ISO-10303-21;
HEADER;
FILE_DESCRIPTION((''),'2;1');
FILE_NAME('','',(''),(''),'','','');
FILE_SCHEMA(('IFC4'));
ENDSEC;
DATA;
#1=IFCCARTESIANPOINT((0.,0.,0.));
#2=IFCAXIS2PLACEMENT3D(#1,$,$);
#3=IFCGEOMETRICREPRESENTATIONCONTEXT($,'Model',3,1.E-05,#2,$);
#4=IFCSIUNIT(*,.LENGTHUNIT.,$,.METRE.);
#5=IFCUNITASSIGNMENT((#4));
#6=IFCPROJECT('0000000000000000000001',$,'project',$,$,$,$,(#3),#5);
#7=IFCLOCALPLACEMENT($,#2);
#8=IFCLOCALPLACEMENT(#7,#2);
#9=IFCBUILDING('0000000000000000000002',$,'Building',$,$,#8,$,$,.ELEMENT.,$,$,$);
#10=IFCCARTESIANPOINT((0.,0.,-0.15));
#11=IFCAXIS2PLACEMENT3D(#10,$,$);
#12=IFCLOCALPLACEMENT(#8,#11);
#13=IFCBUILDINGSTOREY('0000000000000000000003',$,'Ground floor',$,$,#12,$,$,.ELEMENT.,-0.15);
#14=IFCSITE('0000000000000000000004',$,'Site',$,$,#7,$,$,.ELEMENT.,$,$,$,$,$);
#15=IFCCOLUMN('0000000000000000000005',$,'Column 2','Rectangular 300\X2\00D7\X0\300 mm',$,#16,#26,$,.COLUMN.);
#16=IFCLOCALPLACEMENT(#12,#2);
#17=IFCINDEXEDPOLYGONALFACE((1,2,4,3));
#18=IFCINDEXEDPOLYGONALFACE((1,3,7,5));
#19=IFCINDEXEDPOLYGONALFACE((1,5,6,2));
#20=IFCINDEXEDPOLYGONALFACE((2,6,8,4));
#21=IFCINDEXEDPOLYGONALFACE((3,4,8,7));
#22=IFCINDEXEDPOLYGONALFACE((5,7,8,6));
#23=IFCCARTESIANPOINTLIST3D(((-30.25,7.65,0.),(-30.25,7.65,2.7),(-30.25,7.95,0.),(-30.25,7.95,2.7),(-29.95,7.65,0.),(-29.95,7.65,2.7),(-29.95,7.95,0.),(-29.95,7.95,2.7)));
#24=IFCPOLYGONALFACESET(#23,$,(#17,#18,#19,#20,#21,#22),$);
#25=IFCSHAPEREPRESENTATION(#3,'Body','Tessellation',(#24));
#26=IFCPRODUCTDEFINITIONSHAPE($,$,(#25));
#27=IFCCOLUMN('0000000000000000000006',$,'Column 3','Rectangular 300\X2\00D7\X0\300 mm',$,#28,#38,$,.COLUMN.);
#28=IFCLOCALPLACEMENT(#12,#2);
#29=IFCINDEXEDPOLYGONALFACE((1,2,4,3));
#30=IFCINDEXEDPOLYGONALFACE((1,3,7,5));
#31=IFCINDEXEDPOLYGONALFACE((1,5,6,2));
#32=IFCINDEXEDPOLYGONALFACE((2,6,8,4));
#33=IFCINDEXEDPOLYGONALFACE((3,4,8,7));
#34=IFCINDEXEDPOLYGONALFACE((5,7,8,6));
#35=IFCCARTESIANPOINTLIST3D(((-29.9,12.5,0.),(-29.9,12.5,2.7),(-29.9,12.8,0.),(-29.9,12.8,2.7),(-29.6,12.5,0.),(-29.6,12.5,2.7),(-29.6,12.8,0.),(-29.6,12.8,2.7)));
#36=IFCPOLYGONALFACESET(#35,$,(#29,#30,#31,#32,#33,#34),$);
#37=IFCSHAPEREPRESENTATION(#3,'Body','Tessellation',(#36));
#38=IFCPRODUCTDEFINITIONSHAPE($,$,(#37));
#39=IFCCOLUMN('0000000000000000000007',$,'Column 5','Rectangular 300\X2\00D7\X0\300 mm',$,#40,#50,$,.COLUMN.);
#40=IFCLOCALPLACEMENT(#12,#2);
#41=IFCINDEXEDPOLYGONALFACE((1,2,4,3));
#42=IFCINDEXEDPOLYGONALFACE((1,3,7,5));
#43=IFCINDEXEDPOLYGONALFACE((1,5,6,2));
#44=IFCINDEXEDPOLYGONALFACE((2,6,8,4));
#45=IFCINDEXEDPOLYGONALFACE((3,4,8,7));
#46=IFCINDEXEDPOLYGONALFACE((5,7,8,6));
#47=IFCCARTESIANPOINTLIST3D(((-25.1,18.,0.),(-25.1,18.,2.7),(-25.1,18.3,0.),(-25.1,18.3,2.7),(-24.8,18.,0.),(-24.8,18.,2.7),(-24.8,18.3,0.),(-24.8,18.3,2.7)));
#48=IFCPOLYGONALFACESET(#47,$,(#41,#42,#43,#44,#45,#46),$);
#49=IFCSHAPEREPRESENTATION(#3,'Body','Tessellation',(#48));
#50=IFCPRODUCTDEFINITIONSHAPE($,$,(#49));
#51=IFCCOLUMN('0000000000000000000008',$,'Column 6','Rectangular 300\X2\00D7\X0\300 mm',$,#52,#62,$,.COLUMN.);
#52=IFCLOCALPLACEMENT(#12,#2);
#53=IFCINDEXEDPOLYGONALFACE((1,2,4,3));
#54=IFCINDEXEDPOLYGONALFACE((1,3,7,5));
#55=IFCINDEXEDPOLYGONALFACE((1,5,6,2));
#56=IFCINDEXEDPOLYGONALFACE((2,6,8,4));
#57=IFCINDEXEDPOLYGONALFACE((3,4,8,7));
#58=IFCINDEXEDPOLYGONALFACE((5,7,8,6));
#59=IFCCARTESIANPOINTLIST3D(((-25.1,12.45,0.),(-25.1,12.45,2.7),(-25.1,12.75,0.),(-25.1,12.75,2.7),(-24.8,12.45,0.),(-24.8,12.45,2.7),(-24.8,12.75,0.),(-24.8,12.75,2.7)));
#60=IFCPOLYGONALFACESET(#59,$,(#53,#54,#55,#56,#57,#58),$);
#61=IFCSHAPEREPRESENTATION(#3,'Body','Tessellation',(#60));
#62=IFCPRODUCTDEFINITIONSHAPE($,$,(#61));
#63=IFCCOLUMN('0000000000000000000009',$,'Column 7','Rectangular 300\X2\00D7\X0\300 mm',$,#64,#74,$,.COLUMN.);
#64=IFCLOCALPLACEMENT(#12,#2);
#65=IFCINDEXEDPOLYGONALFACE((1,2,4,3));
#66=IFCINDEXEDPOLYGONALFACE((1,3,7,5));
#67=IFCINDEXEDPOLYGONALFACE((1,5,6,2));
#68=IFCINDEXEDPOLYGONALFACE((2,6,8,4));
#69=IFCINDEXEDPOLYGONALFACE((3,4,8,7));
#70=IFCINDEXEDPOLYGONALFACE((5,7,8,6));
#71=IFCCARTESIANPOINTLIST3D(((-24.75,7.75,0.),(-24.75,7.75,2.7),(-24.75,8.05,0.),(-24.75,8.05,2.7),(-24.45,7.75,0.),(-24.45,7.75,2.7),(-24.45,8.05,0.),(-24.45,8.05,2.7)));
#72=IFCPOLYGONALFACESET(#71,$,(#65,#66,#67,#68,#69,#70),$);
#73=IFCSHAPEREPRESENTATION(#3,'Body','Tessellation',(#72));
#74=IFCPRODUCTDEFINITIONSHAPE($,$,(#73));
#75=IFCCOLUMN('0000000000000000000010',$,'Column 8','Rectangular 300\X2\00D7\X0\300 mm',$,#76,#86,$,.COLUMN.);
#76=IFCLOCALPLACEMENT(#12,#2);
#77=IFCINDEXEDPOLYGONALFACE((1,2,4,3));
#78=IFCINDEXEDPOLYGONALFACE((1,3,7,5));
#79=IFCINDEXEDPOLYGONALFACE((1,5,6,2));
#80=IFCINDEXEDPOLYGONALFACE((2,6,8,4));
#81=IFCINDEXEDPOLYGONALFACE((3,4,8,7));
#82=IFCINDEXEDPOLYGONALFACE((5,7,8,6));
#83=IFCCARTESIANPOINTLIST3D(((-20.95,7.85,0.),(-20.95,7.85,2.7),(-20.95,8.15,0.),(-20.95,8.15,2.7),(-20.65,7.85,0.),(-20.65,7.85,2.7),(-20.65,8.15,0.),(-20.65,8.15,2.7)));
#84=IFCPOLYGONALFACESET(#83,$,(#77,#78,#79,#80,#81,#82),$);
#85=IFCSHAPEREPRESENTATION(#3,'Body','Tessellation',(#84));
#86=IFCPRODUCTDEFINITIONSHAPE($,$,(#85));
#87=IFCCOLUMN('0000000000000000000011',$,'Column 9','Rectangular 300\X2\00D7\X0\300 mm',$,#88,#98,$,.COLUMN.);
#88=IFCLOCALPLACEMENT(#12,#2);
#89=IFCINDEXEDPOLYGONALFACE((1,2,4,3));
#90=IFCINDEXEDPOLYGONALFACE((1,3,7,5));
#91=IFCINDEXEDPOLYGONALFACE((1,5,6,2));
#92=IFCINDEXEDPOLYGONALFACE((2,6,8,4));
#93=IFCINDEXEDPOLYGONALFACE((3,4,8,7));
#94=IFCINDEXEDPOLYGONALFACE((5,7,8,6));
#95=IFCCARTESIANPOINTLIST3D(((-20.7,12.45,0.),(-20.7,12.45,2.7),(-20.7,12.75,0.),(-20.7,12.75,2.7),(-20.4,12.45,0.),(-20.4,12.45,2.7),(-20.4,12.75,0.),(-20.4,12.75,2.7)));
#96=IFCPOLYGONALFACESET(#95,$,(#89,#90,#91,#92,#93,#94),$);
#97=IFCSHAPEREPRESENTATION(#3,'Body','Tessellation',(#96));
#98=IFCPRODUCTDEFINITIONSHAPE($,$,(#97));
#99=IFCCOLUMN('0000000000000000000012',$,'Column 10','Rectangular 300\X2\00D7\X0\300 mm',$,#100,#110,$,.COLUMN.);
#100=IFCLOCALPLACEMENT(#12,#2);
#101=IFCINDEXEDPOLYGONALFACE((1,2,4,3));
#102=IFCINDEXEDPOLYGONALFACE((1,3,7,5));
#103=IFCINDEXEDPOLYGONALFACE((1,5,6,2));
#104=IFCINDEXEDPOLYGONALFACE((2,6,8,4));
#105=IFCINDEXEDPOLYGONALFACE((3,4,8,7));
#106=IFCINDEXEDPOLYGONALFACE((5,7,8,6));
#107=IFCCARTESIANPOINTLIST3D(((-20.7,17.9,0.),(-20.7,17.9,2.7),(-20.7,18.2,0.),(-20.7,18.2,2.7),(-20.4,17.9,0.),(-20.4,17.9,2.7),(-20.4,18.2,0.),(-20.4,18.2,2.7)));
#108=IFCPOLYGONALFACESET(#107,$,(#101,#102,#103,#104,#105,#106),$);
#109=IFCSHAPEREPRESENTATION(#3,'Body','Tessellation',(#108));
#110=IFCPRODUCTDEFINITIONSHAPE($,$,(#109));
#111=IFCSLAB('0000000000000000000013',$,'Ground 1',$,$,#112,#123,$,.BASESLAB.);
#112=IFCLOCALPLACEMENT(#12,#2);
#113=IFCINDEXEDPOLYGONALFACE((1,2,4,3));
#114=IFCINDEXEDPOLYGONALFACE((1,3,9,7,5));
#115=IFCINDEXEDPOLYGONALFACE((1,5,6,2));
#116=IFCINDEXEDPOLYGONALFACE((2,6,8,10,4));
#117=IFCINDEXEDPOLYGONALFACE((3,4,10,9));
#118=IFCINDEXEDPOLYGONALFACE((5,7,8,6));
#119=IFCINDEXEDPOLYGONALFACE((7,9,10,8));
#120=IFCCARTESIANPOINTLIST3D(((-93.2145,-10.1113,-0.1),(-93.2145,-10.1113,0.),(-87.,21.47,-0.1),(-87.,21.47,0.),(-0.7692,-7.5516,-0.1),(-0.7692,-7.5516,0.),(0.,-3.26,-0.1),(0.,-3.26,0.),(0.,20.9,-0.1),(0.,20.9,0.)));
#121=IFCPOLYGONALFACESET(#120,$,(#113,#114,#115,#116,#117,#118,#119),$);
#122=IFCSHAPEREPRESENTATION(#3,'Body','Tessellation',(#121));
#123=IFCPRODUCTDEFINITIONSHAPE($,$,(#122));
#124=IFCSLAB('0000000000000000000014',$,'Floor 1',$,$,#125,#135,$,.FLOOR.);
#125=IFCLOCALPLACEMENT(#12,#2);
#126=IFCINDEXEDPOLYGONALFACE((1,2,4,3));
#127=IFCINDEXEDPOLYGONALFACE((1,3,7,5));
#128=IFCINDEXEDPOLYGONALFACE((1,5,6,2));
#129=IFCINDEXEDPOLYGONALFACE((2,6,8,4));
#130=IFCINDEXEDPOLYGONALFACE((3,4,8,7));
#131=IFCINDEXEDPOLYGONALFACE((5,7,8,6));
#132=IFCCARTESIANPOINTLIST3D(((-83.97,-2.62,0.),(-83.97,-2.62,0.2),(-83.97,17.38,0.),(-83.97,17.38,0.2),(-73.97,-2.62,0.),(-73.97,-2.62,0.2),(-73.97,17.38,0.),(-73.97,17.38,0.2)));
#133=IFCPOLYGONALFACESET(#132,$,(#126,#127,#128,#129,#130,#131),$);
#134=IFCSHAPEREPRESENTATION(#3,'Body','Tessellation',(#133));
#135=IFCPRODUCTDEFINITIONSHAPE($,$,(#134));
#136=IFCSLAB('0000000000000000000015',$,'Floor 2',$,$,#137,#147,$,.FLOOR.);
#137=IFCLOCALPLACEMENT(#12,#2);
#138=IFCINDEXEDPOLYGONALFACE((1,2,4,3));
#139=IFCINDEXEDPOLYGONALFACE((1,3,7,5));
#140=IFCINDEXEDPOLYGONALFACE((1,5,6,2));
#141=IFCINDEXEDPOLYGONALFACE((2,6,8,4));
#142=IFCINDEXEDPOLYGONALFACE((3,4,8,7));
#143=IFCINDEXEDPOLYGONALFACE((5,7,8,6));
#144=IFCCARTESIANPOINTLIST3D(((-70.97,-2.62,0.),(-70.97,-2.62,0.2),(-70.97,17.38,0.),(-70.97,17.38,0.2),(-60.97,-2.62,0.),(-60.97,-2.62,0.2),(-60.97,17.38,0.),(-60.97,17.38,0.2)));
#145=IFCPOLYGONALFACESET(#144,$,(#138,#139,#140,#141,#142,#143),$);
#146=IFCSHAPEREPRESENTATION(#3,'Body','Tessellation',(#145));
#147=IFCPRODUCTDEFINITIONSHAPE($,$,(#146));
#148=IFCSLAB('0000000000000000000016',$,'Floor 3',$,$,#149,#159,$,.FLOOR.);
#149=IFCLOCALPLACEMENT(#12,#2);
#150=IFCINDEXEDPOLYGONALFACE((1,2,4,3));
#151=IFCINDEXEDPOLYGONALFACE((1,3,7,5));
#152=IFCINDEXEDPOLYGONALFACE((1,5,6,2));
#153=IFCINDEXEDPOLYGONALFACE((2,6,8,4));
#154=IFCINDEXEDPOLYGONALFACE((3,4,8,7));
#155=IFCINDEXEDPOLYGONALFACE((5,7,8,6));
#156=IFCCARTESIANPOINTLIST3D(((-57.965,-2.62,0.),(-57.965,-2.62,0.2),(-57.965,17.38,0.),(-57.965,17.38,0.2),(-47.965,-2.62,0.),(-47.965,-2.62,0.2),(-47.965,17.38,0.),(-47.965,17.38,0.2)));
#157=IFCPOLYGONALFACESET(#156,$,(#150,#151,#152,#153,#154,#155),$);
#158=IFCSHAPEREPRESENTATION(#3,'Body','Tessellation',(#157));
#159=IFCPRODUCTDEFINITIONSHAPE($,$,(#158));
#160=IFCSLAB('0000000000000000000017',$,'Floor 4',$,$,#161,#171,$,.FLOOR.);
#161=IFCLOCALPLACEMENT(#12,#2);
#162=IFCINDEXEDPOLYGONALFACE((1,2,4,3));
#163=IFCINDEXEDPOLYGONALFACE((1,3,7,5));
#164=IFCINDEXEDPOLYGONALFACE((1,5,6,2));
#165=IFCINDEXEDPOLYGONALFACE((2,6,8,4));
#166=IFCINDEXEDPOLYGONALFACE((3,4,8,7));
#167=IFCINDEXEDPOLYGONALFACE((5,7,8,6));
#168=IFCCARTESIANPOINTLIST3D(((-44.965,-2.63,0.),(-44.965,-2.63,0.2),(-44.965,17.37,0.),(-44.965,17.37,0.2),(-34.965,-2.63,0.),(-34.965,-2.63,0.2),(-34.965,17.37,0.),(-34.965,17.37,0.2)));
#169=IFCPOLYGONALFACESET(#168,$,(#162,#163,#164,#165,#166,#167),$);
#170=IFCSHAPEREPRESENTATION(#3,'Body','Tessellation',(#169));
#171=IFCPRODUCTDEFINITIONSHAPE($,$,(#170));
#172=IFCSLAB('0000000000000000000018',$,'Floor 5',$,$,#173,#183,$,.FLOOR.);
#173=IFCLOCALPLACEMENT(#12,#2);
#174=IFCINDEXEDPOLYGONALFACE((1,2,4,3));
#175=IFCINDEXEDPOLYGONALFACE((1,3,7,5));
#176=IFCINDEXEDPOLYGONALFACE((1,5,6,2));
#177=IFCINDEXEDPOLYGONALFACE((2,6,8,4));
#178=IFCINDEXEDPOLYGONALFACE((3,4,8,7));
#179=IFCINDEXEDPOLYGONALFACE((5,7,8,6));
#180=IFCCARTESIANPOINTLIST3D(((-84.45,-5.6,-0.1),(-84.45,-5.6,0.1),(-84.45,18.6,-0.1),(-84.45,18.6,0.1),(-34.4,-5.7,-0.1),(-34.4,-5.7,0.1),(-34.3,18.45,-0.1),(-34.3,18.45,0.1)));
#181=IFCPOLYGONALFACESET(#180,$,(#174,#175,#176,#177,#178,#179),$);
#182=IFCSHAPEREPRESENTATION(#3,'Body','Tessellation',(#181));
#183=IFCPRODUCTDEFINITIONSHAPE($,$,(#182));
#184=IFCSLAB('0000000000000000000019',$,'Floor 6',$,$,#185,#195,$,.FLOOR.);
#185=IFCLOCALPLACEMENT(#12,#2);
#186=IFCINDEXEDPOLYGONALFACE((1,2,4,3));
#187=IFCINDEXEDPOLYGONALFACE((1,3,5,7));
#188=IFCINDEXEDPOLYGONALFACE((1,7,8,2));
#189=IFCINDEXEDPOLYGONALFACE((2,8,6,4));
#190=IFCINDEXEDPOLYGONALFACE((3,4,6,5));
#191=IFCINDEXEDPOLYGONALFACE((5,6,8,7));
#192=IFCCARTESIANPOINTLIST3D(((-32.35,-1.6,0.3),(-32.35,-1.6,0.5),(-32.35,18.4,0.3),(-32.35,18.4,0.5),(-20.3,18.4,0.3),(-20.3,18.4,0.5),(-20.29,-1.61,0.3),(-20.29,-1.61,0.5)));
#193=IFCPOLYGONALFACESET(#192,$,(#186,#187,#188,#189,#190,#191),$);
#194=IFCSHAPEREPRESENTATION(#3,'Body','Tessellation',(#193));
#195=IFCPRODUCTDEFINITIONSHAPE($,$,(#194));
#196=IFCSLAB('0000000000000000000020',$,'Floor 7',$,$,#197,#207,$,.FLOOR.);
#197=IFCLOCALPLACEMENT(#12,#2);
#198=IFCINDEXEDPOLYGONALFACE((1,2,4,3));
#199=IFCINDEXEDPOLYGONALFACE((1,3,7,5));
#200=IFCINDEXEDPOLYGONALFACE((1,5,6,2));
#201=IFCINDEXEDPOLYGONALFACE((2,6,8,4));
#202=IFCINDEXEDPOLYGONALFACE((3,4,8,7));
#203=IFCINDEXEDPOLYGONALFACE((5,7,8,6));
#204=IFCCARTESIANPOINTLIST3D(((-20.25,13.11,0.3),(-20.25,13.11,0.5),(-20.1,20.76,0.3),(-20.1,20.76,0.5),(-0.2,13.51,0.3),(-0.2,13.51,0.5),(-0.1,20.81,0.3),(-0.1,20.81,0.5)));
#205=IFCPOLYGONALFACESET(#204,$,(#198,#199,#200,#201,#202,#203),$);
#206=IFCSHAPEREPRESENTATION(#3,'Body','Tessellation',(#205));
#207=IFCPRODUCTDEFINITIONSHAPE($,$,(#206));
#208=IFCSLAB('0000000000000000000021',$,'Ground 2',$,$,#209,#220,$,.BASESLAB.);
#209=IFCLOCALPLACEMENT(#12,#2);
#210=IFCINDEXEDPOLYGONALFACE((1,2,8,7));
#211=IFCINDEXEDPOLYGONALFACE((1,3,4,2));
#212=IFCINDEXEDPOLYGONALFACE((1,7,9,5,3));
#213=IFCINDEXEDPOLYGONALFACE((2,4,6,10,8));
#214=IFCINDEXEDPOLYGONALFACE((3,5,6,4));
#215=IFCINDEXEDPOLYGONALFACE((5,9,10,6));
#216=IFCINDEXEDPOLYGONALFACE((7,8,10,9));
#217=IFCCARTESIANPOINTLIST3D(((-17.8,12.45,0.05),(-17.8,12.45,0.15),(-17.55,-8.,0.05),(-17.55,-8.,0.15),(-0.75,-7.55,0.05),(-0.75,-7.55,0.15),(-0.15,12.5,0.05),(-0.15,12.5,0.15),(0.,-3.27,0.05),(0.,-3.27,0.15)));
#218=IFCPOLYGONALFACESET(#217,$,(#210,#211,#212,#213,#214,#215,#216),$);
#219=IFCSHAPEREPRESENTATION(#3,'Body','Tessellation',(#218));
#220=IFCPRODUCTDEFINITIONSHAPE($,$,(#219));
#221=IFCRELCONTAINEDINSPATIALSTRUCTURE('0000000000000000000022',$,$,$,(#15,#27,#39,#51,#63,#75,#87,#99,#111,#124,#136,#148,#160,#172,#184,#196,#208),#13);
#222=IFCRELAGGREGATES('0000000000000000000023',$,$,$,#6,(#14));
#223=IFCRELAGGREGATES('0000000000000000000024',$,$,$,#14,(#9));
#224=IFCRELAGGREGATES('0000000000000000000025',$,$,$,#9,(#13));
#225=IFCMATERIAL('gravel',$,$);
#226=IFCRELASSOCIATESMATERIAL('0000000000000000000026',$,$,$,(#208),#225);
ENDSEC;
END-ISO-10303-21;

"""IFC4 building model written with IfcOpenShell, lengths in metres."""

from ifc_helpers import new_model, si_unit, frame, origin, origin_with_axes, place, context, project, spatial, polyline, outline, extrude, material, element, save


model = new_model("IFC4")

# Units and contexts
model_context = context("Model", 3, precision=1e-05, world=origin())
ifc_project = project(units=[si_unit("LENGTHUNIT", "METRE")], contexts=[model_context])

# Site, building, storey
site_placement = place(None, origin())
site = spatial("IfcSite", under=ifc_project, at=site_placement, Name="Site", CompositionType="ELEMENT")
building_placement = place(site_placement, origin())
building = spatial("IfcBuilding", under=site, at=building_placement, Name="Building", CompositionType="ELEMENT")
storey_placement = place(building_placement, frame((0.0, 0.0, -0.15)))
storey = spatial("IfcBuildingStorey", under=building, at=storey_placement, Name="Ground floor", CompositionType="ELEMENT", Elevation=-0.15)

# Columns
for number, where, z_axis, x_axis, name in (
    (1, (-30.1, 7.8, 0.0), (0.0, 0.0, 1.0), (1.0, 0.0, 0.0), "Column 2"),
    (2, (-29.75, 12.65, 0.0), (0.0, 0.0, 1.0), (1.0, 0.0, 0.0), "Column 3"),
    (3, (-24.95, 18.15, 0.0), (0.0, 0.0, 1.0), (1.0, 0.0, 0.0), "Column 5"),
    (4, (-24.95, 12.6, 0.0), (0.0, 0.0, 1.0), (1.0, 0.0, 0.0), "Column 6"),
    (5, (-24.6, 7.9, 0.0), (0.0, 0.0, 1.0), (1.0, 0.0, 0.0), "Column 7"),
    (6, (-20.8, 8.0, 0.0), (0.0, 0.0, 1.0), (1.0, 0.0, 0.0), "Column 8"),
    (7, (-20.55, 12.6, 0.0), (0.0, 0.0, 1.0), (1.0, 0.0, 0.0), "Column 9"),
    (8, (-20.55, 18.05, 0.0), (0.0, 0.0, 1.0), (1.0, 0.0, 0.0), "Column 10"),
):
    element("IfcColumn", number, at=place(storey_placement, frame(where, z_axis=z_axis, x_axis=x_axis)), inside=storey, Name=name, Description="Rectangular 300×300 mm", PredefinedType="COLUMN", context=model_context, shape_type="SweptSolid", body=[
        extrude(outline(polyline([(-0.15, -0.15), (0.15, -0.15), (0.15, 0.15), (-0.15, 0.15), (-0.15, -0.15)])), origin(), (0.0, 0.0, 1.0), 2.7),
    ])

# Slabs
slab_1_placement = place(storey_placement, frame((0.0, 0.0, -0.1), z_axis=(0.0, 0.0, 1.0), x_axis=(1.0, 0.0, 0.0)))
element("IfcSlab", 9, at=slab_1_placement, inside=storey, Name="Ground 1", PredefinedType="BASESLAB", context=model_context, shape_type="SweptSolid", body=[
    extrude(outline(polyline([(-87.0, 21.47), (0.0, 20.9), (0.0, -3.26), (-0.7692, -7.5516), (-93.2145, -10.1113), (-87.0, 21.47)])), origin(), (0.0, 0.0, 1.0), 0.1),
])
slab_2_placement = place(storey_placement, origin_with_axes())
element("IfcSlab", 10, at=slab_2_placement, inside=storey, Name="Floor 1", PredefinedType="FLOOR", context=model_context, shape_type="SweptSolid", body=[
    extrude(outline(polyline([(-83.97, -2.62), (-83.97, 17.38), (-73.97, 17.38), (-73.97, -2.62), (-83.97, -2.62)])), origin(), (0.0, 0.0, 1.0), 0.2),
])
slab_3_placement = place(storey_placement, origin_with_axes())
element("IfcSlab", 11, at=slab_3_placement, inside=storey, Name="Floor 2", PredefinedType="FLOOR", context=model_context, shape_type="SweptSolid", body=[
    extrude(outline(polyline([(-70.97, -2.62), (-70.97, 17.38), (-60.97, 17.38), (-60.97, -2.62), (-70.97, -2.62)])), origin(), (0.0, 0.0, 1.0), 0.2),
])
slab_4_placement = place(storey_placement, origin_with_axes())
element("IfcSlab", 12, at=slab_4_placement, inside=storey, Name="Floor 3", PredefinedType="FLOOR", context=model_context, shape_type="SweptSolid", body=[
    extrude(outline(polyline([(-57.965, -2.62), (-57.965, 17.38), (-47.965, 17.38), (-47.965, -2.62), (-57.965, -2.62)])), origin(), (0.0, 0.0, 1.0), 0.2),
])
slab_5_placement = place(storey_placement, origin_with_axes())
element("IfcSlab", 13, at=slab_5_placement, inside=storey, Name="Floor 4", PredefinedType="FLOOR", context=model_context, shape_type="SweptSolid", body=[
    extrude(outline(polyline([(-44.965, -2.63), (-44.965, 17.37), (-34.965, 17.37), (-34.965, -2.63), (-44.965, -2.63)])), origin(), (0.0, 0.0, 1.0), 0.2),
])
slab_6_placement = place(storey_placement, frame((0.0, 0.0, -0.1), z_axis=(0.0, 0.0, 1.0), x_axis=(1.0, 0.0, 0.0)))
element("IfcSlab", 14, at=slab_6_placement, inside=storey, Name="Floor 5", PredefinedType="FLOOR", context=model_context, shape_type="SweptSolid", body=[
    extrude(outline(polyline([(-84.45, -5.6), (-84.45, 18.6), (-34.3, 18.45), (-34.4, -5.7), (-84.45, -5.6)])), origin(), (0.0, 0.0, 1.0), 0.2),
])
slab_7_placement = place(storey_placement, frame((0.0, 0.0, 0.3), z_axis=(0.0, 0.0, 1.0), x_axis=(1.0, 0.0, 0.0)))
element("IfcSlab", 15, at=slab_7_placement, inside=storey, Name="Floor 6", PredefinedType="FLOOR", context=model_context, shape_type="SweptSolid", body=[
    extrude(outline(polyline([(-32.35, -1.6), (-32.35, 18.4), (-20.3, 18.4), (-20.29, -1.61), (-32.35, -1.6)])), origin(), (0.0, 0.0, 1.0), 0.2),
])
slab_8_placement = place(storey_placement, frame((0.0, 0.0, 0.3), z_axis=(0.0, 0.0, 1.0), x_axis=(1.0, 0.0, 0.0)))
element("IfcSlab", 16, at=slab_8_placement, inside=storey, Name="Floor 7", PredefinedType="FLOOR", context=model_context, shape_type="SweptSolid", body=[
    extrude(outline(polyline([(-20.25, 13.11), (-20.1, 20.76), (-0.1, 20.81), (-0.2, 13.51), (-20.25, 13.11)])), origin(), (0.0, 0.0, 1.0), 0.2),
])
ifc_material = material(Name="gravel")
slab_9_placement = place(storey_placement, frame((0.0, 0.0, 0.05), z_axis=(0.0, 0.0, 1.0), x_axis=(1.0, 0.0, 0.0)))
element("IfcSlab", 17, at=slab_9_placement, inside=storey, material=ifc_material, Name="Ground 2", PredefinedType="BASESLAB", context=model_context, shape_type="SweptSolid", body=[
    extrude(outline(polyline([(-0.15, 12.5), (-17.8, 12.45), (-17.55, -8.0), (-0.75, -7.55), (0.0, -3.27), (-0.15, 12.5)])), origin(), (0.0, 0.0, 1.0), 0.1),
])

save(model, "model.ifc")
